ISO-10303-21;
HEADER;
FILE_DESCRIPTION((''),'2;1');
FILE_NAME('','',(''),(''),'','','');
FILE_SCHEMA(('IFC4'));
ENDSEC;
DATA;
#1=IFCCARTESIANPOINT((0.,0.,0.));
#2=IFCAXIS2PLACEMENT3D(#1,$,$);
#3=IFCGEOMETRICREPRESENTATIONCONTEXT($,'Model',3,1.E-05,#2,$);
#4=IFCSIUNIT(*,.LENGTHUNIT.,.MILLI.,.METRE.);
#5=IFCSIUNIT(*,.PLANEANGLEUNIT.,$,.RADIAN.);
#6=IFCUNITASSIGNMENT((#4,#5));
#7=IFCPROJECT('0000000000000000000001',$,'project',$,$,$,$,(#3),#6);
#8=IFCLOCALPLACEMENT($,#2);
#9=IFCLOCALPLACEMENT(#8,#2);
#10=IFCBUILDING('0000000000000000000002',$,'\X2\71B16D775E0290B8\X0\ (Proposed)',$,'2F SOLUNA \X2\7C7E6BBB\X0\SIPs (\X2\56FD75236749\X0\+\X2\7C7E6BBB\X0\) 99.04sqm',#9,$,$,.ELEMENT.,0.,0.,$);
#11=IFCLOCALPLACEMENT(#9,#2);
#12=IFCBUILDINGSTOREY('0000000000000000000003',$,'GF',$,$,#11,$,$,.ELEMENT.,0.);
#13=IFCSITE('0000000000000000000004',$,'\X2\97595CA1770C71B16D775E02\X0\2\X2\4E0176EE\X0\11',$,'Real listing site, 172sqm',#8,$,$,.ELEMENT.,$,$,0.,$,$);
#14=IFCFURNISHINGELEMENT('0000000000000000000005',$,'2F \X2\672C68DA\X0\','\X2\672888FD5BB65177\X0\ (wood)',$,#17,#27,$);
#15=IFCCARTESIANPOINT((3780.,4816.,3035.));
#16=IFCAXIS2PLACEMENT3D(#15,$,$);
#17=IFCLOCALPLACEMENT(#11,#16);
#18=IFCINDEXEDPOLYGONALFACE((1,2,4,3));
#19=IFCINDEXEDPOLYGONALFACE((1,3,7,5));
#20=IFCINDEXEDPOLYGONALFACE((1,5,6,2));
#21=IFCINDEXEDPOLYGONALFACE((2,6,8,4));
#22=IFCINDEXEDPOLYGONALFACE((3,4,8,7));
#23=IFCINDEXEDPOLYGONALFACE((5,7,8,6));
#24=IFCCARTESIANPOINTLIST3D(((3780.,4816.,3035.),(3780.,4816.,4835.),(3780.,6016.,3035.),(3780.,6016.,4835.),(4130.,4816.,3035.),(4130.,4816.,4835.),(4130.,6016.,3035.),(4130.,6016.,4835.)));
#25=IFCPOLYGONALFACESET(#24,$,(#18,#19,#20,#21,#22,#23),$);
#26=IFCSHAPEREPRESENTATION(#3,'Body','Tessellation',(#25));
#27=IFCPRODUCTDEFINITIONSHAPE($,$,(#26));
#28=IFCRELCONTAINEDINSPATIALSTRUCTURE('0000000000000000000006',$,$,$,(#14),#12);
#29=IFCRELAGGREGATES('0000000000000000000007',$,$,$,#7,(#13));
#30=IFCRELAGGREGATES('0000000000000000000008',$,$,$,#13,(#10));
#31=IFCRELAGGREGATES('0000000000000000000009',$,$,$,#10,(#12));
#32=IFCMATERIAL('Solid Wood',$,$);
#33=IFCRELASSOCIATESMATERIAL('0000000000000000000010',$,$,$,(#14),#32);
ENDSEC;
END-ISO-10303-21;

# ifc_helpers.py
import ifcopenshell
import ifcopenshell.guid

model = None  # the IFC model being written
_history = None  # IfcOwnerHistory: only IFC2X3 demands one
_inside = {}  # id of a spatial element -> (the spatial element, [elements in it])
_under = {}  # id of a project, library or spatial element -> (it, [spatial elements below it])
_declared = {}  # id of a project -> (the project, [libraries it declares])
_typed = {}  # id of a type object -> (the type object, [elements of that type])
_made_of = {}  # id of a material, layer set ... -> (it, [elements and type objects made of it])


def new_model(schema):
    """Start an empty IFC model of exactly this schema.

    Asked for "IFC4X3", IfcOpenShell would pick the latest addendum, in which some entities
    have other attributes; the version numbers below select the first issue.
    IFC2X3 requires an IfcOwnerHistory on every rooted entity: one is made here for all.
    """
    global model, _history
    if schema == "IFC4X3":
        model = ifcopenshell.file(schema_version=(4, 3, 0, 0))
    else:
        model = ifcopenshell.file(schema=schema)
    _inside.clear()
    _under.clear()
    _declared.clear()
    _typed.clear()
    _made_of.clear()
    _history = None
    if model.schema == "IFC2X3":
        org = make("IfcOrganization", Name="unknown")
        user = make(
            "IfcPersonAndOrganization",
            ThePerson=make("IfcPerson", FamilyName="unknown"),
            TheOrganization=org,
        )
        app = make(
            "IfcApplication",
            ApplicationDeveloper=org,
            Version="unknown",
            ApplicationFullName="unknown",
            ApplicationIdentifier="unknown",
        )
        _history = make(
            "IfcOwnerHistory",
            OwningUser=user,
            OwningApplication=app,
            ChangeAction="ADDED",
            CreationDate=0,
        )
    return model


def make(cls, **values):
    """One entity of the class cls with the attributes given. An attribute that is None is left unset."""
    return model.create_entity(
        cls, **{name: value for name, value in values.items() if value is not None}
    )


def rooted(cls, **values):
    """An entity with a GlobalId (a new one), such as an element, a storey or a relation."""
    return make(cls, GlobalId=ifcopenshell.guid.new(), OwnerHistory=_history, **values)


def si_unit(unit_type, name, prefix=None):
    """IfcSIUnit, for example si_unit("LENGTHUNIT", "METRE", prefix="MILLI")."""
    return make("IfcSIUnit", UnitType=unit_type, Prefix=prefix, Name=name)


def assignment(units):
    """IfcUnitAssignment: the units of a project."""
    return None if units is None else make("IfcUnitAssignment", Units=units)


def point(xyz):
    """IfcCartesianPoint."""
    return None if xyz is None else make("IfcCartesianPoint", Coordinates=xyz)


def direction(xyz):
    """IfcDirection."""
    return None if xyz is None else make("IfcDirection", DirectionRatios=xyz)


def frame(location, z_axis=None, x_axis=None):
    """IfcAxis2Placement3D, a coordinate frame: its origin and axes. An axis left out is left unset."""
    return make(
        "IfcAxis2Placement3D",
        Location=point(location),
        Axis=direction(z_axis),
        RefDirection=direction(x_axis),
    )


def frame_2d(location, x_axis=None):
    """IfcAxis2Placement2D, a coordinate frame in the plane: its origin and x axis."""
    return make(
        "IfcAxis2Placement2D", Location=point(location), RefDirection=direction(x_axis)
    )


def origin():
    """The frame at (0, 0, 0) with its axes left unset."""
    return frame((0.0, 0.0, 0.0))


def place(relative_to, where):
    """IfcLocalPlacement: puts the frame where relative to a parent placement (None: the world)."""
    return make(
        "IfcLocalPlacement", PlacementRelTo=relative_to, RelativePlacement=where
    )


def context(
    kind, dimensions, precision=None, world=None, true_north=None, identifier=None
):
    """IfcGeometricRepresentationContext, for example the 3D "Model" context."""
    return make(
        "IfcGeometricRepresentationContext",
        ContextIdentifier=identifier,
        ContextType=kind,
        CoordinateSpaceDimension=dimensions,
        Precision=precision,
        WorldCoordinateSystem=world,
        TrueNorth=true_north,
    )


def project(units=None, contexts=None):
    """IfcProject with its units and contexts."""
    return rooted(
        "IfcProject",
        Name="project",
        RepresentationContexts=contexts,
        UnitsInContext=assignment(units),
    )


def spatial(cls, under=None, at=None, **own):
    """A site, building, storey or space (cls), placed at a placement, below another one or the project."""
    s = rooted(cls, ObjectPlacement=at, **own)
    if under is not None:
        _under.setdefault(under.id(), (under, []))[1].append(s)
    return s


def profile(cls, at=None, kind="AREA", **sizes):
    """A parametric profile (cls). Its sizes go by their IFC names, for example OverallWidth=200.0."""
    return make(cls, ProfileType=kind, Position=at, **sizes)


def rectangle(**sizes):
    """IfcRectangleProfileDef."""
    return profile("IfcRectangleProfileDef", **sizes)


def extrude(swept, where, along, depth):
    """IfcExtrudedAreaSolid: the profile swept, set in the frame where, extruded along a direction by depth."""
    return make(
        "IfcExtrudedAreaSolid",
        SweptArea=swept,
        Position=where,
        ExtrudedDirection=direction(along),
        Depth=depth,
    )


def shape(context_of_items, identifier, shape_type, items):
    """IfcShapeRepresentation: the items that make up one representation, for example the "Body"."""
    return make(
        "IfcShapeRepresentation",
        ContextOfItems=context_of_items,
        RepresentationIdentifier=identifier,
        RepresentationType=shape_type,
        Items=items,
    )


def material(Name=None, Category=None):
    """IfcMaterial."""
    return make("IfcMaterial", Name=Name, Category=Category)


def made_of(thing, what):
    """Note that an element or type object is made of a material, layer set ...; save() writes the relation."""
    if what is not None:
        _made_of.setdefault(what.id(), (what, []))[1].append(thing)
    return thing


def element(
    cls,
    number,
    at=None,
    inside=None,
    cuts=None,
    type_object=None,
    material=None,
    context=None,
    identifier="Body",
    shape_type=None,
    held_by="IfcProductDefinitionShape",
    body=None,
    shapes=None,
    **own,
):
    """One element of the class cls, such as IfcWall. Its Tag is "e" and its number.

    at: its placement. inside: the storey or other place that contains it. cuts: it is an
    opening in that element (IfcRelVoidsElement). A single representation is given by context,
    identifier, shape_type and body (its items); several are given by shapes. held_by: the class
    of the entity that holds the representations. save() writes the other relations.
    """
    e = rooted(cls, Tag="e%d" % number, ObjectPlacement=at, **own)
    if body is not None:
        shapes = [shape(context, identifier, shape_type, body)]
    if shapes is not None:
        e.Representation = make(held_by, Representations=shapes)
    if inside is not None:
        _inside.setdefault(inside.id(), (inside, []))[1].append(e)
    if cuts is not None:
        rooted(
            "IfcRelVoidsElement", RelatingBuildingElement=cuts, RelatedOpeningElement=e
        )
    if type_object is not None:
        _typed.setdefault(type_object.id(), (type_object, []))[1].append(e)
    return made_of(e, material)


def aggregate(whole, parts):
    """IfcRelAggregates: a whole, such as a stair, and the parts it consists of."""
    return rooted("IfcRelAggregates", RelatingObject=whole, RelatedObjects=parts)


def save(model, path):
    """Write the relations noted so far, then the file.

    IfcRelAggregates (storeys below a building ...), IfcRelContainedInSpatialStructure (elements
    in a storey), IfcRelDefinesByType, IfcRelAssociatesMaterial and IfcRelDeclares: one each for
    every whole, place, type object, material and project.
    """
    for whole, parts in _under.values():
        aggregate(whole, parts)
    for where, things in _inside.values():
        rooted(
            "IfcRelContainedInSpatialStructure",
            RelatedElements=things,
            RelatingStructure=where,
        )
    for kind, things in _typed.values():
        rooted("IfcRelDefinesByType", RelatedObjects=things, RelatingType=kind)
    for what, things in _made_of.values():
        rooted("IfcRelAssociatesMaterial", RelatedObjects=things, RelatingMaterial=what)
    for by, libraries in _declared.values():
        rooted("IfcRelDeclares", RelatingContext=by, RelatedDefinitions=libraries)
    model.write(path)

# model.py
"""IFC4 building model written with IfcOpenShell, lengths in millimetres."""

from ifc_helpers import new_model, si_unit, frame, frame_2d, origin, place, context, project, spatial, rectangle, extrude, material, element, save


model = new_model("IFC4")

# Units and contexts
model_context = context("Model", 3, precision=1e-05, world=origin())
ifc_project = project(units=[si_unit("LENGTHUNIT", "METRE", prefix="MILLI"), si_unit("PLANEANGLEUNIT", "RADIAN")], contexts=[model_context])

# Site, building, storey
site_placement = place(None, origin())
site = spatial("IfcSite", under=ifc_project, at=site_placement, Name="静岡県熱海市2丁目11", ObjectType="Real listing site, 172sqm", CompositionType="ELEMENT", RefElevation=0.0)
building_placement = place(site_placement, origin())
building = spatial("IfcBuilding", under=site, at=building_placement, Name="熱海市邸 (Proposed)", ObjectType="2F SOLUNA 籾殻SIPs (国産杉+籾殻) 99.04sqm", CompositionType="ELEMENT", ElevationOfRefHeight=0.0, ElevationOfTerrain=0.0)
storey_placement = place(building_placement, origin())
storey = spatial("IfcBuildingStorey", under=building, at=storey_placement, Name="GF", CompositionType="ELEMENT", Elevation=0.0)

# Shared definitions
ifc_material_1 = material(Name="Solid Wood")

# Furnishing element
furnishing_placement = place(storey_placement, frame((3780.0, 4816.0, 3035.0)))
element("IfcFurnishingElement", 1, at=furnishing_placement, inside=storey, material=ifc_material_1, Name="2F 本棚", Description="木製家具 (wood)", context=model_context, shape_type="SweptSolid", body=[
    extrude(rectangle(XDim=350.0, YDim=1200.0, at=frame_2d((175.0, 600.0))), frame((3780.0, 4816.0, 3035.0)), (0.0, 0.0, 1.0), 1800.0),
])

save(model, "model.ifc")
